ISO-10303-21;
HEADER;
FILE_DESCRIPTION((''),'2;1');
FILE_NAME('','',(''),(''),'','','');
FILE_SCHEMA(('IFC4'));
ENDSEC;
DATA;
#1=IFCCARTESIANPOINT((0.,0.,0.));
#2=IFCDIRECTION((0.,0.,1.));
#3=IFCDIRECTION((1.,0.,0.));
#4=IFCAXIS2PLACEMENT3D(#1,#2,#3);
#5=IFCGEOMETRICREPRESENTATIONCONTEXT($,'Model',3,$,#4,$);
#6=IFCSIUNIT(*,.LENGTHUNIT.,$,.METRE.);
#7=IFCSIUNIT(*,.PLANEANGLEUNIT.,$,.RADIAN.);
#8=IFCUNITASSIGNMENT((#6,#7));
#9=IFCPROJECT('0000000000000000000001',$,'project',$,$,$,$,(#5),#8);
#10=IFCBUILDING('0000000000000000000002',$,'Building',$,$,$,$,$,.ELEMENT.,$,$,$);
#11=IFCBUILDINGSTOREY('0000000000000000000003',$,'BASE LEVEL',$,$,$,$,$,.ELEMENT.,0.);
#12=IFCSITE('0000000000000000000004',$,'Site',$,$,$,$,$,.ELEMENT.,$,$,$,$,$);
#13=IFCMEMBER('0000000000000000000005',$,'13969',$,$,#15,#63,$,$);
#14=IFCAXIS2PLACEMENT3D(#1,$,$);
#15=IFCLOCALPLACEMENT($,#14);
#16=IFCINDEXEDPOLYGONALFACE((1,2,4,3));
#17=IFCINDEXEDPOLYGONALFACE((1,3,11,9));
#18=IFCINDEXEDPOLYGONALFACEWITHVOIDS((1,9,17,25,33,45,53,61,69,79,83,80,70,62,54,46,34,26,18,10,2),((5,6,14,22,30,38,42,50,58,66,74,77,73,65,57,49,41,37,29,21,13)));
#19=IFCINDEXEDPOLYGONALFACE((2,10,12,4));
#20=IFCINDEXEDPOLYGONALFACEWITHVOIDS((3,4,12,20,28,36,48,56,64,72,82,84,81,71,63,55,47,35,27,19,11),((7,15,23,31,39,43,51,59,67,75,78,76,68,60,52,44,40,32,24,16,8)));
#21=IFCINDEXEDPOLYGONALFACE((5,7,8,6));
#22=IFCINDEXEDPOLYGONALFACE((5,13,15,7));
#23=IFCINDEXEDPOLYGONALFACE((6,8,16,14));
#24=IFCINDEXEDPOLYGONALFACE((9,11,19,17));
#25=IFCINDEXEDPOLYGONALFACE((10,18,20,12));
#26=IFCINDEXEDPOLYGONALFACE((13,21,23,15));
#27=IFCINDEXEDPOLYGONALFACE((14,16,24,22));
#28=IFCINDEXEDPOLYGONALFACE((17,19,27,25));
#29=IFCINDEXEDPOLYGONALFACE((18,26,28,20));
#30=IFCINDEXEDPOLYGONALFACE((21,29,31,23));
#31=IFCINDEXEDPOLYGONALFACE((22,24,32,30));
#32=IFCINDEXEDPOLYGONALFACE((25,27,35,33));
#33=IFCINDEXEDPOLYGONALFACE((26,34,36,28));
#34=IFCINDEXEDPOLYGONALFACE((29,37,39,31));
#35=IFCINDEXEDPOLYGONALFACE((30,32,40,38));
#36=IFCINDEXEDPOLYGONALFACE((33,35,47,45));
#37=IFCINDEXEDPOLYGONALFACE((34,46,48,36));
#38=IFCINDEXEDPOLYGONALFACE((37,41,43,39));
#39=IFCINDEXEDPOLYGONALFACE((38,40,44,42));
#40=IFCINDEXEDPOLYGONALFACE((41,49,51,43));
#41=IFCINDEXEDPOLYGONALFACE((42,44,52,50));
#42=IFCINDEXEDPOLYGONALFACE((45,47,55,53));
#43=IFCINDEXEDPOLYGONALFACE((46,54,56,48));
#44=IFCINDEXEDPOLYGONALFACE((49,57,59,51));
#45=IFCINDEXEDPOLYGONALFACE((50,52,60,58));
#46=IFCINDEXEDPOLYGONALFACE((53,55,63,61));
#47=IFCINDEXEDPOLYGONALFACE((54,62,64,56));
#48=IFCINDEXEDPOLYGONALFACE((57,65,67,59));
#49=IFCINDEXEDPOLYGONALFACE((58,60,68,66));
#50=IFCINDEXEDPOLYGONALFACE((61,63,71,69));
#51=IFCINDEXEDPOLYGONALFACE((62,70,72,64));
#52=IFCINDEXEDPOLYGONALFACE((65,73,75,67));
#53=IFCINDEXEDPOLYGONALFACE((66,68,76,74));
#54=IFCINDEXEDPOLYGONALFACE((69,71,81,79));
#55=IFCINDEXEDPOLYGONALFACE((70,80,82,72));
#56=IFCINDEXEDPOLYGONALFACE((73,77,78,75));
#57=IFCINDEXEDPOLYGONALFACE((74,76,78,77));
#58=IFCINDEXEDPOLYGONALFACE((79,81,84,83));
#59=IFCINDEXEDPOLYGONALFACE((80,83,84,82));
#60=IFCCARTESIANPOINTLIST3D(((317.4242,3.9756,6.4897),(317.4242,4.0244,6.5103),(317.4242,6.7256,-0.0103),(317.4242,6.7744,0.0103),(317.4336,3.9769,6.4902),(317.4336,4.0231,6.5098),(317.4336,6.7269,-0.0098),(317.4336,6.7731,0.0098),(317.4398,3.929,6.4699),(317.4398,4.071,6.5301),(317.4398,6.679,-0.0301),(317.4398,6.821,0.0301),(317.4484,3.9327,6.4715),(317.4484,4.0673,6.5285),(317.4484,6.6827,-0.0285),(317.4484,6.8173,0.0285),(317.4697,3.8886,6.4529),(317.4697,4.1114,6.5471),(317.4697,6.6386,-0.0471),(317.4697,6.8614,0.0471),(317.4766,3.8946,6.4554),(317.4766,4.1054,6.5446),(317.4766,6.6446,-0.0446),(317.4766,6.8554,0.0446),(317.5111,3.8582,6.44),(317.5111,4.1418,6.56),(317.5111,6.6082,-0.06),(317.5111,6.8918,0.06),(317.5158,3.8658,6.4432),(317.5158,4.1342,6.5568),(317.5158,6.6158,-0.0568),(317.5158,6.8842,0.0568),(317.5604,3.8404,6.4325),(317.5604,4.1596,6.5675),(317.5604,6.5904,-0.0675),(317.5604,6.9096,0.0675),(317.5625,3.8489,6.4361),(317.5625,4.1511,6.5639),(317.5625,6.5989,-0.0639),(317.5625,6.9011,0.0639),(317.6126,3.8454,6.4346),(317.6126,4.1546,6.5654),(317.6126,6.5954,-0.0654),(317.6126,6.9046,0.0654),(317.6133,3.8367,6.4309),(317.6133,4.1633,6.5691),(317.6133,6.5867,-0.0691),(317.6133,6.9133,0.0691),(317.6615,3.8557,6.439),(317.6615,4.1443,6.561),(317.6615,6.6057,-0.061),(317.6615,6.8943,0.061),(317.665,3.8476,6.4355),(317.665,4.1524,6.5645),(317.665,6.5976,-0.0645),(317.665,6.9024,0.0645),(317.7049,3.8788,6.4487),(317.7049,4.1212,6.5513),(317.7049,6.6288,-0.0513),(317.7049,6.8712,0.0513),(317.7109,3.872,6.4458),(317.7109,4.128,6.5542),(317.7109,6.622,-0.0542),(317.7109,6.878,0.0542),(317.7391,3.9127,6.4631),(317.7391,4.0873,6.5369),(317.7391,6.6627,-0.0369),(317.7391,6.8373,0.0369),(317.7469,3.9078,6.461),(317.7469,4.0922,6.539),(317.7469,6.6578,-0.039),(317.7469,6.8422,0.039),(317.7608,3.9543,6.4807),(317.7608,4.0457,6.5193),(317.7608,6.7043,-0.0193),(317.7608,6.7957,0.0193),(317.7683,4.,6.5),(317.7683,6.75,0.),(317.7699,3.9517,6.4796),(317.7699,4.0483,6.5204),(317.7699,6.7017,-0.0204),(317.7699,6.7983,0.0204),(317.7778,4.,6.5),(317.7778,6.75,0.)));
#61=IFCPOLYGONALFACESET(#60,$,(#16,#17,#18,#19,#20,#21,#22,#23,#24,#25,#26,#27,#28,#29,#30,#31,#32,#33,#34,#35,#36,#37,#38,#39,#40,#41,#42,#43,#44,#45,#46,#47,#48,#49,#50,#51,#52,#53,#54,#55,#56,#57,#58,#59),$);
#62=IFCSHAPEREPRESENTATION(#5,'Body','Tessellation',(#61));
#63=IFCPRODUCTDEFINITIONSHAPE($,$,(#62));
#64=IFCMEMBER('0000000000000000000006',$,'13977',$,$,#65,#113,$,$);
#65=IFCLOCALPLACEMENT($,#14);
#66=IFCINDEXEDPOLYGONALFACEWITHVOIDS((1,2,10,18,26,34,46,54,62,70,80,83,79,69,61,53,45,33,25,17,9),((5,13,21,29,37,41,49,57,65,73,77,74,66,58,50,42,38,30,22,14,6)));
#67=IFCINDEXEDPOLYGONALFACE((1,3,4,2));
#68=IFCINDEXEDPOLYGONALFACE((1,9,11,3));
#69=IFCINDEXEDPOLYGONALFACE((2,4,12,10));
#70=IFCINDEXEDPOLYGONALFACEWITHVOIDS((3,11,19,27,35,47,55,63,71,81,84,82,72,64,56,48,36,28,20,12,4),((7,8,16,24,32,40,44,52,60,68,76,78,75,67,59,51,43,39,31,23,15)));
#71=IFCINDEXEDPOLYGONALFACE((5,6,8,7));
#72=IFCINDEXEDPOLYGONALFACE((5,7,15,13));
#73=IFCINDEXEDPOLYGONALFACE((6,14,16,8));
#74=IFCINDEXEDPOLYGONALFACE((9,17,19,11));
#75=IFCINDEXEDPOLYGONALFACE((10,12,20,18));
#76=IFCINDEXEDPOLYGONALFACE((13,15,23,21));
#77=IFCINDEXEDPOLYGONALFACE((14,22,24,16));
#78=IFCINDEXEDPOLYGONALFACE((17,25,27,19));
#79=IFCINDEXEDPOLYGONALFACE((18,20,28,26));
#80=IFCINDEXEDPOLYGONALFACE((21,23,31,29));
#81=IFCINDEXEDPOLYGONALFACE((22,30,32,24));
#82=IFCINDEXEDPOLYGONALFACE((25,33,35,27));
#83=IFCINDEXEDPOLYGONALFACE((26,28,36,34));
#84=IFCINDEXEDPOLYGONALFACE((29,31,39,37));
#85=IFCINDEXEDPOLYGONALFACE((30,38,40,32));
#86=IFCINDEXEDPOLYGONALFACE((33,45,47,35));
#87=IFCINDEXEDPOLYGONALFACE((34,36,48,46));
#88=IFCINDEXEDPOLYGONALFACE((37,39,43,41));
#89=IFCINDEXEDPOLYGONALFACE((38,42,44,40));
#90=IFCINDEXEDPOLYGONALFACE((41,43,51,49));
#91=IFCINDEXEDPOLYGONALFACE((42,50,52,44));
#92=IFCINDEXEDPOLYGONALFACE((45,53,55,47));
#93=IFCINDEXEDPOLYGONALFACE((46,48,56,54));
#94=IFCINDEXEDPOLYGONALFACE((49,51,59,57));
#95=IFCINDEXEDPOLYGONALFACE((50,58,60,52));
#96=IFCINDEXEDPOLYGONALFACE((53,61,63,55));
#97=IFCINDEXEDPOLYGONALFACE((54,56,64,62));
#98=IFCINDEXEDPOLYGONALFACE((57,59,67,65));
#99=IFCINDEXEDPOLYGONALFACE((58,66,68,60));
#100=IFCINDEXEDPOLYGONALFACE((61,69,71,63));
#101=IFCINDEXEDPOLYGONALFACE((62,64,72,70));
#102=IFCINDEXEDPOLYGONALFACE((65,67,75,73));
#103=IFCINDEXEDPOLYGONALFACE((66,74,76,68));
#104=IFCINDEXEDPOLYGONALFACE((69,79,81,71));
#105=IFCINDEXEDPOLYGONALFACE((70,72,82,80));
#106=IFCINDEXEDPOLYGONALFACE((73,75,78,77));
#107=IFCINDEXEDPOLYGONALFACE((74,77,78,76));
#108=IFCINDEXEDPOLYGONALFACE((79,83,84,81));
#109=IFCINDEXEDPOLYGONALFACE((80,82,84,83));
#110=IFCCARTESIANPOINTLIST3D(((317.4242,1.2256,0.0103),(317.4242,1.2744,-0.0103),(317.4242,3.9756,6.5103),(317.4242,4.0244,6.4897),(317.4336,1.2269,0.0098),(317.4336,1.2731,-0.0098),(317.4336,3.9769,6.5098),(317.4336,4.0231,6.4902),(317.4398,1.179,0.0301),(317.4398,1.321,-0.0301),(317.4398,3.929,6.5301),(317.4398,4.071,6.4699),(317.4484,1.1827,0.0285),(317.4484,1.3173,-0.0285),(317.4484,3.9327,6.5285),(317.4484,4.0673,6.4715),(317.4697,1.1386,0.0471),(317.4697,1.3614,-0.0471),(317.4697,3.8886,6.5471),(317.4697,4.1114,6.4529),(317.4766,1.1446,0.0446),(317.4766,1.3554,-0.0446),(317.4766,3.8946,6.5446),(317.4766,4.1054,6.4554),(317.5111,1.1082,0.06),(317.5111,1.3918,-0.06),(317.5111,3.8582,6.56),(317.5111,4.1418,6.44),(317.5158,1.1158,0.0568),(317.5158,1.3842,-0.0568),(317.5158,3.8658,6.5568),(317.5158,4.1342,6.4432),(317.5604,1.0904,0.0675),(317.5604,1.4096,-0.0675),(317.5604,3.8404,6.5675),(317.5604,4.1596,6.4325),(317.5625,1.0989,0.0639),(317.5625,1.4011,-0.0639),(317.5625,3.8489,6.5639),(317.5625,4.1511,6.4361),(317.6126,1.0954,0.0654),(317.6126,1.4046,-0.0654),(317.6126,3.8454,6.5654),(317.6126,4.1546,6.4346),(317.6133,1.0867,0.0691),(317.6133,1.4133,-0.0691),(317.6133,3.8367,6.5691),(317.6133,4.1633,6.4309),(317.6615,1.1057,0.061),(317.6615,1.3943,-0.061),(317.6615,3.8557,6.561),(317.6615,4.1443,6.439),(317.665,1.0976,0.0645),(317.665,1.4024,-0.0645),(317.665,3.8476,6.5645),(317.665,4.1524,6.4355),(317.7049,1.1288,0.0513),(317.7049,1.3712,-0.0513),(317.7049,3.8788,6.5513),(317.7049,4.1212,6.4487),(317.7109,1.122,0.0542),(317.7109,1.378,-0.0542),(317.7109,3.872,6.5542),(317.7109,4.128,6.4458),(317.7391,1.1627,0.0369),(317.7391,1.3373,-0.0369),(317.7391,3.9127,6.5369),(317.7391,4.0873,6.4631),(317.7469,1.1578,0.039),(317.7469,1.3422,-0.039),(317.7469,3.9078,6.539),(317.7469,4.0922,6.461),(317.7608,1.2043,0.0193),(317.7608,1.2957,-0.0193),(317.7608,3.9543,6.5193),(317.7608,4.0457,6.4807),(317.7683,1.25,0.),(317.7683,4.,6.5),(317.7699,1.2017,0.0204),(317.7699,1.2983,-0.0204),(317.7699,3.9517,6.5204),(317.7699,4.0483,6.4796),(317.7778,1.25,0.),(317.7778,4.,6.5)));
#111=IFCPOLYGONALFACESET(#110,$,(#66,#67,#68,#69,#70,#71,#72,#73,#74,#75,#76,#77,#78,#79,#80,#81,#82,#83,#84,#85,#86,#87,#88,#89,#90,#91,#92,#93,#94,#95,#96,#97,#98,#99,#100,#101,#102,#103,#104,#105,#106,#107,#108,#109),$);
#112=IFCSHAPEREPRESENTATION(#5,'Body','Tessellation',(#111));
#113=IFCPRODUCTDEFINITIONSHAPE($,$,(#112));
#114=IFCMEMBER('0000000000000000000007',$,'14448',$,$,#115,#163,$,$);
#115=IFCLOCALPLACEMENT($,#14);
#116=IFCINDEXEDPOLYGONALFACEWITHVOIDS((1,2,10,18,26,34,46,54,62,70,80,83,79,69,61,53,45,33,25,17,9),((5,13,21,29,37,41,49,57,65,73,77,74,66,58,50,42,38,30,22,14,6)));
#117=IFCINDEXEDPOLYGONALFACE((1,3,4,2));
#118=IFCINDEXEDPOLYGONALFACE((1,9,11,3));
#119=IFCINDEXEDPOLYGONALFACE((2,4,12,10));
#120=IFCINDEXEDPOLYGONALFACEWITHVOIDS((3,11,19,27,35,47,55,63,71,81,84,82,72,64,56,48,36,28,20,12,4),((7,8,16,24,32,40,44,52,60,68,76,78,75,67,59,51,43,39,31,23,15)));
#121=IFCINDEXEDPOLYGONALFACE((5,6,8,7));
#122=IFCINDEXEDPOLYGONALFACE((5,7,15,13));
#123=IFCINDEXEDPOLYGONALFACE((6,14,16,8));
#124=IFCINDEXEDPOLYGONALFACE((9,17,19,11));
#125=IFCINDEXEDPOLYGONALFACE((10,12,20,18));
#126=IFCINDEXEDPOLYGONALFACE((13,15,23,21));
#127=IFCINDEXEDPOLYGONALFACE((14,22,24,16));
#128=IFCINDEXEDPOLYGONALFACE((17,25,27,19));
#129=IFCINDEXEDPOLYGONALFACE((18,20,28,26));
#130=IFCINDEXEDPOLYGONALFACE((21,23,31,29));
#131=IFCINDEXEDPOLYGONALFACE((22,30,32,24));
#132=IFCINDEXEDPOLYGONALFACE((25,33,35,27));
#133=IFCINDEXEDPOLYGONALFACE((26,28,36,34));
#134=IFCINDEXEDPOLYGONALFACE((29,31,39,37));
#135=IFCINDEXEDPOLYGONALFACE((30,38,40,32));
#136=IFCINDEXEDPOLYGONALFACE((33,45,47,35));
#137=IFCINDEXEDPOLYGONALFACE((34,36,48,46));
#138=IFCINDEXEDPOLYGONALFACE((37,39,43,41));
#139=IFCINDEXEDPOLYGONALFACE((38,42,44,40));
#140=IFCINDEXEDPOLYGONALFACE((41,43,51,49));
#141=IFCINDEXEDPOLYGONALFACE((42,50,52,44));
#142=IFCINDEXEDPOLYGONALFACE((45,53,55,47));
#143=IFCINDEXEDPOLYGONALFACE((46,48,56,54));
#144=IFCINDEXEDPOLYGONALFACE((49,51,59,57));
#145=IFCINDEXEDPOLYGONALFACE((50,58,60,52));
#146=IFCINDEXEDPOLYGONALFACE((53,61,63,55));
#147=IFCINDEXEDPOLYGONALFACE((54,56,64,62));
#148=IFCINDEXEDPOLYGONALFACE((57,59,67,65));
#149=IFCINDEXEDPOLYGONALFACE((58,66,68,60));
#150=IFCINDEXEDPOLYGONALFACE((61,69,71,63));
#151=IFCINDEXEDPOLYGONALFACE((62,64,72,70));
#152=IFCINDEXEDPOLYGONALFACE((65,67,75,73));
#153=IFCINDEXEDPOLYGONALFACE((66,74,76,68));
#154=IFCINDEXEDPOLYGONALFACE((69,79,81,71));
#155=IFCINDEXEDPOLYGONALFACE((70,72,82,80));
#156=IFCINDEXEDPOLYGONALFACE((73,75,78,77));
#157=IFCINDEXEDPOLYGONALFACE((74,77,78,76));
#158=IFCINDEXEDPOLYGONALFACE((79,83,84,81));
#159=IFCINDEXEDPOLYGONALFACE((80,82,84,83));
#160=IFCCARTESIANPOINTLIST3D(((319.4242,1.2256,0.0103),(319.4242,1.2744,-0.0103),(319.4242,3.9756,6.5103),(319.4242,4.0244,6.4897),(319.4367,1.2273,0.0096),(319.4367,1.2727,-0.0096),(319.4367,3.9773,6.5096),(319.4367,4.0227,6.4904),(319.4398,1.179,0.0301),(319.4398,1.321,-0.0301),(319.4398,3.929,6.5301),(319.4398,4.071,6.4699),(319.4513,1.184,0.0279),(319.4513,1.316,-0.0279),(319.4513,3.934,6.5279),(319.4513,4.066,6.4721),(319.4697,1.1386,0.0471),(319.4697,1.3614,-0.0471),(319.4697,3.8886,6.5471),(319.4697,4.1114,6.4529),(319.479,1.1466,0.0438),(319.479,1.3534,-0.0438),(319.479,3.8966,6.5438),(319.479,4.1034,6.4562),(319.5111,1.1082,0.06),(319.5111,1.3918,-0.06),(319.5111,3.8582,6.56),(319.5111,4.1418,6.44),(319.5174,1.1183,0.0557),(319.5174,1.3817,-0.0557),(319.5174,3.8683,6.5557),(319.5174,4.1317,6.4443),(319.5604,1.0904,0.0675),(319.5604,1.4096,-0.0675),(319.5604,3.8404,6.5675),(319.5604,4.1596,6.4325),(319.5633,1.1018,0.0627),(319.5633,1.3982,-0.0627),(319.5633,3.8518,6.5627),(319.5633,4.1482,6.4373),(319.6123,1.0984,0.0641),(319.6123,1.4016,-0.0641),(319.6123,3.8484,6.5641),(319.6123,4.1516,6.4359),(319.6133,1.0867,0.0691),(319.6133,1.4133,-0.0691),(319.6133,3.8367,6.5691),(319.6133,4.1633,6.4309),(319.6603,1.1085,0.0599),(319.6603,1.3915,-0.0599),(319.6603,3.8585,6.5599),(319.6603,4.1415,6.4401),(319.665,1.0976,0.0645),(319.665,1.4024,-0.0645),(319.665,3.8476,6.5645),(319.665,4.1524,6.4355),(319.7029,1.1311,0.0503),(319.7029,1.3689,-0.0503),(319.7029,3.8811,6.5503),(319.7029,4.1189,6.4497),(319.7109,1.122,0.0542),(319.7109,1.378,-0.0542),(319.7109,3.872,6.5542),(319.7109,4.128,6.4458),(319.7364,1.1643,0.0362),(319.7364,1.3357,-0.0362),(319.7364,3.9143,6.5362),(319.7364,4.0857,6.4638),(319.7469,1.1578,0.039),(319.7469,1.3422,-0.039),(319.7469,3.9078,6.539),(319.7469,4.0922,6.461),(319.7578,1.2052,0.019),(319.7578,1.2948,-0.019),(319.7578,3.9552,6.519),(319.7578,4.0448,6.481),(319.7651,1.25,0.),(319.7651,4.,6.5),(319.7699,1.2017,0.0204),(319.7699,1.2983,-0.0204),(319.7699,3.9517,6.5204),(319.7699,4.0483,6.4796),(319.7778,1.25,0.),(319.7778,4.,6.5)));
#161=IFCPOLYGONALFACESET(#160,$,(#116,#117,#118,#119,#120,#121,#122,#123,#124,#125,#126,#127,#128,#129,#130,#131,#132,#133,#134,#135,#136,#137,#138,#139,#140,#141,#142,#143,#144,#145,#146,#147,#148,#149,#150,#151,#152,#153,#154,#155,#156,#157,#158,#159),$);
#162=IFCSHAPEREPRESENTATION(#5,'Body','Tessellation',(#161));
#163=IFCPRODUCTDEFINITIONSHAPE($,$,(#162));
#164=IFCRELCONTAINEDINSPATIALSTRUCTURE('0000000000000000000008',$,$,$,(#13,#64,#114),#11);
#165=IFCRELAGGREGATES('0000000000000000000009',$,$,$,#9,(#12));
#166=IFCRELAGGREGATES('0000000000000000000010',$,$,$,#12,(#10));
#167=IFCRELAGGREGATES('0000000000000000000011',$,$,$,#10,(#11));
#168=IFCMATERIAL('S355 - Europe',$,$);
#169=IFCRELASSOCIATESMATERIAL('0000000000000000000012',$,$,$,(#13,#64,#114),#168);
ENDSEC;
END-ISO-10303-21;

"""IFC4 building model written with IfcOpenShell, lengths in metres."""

from ifc_helpers import new_model, si_unit, frame, origin_with_axes, origin_2d_with_axis, place, context, project, spatial, hollow_circle, extrude, material, material_profile, profile_set, profile_usage, element, save


model = new_model("IFC4")

# Units and contexts
model_context = context("Model", 3, world=origin_with_axes())
ifc_project = project(units=[si_unit("LENGTHUNIT", "METRE"), si_unit("PLANEANGLEUNIT", "RADIAN")], contexts=[model_context])

# Site, building, storey
site = spatial("IfcSite", under=ifc_project, Name="Site", CompositionType="ELEMENT")
building = spatial("IfcBuilding", under=site, Name="Building", CompositionType="ELEMENT")
storey = spatial("IfcBuildingStorey", under=building, Name="BASE LEVEL", CompositionType="ELEMENT", Elevation=0.0)

# Shared definitions
ifc_material = material(Name="S355 - Europe")

# Members
ifc_material_profile_1 = material_profile(ifc_material, hollow_circle(Radius=0.1778, WallThickness=0.0095, at=origin_2d_with_axis()))
ifc_profile_set_1 = profile_set([ifc_material_profile_1])
ifc_profile_usage_1 = profile_usage(ifc_profile_set_1, cardinal=10)
member_1_placement = place(None, frame((317.6, 6.75, 0.0), z_axis=(0.0, -0.38964, 0.920967), x_axis=(1.0, 0.0, 0.0)))
element("IfcMember", 1, at=member_1_placement, inside=storey, material=ifc_profile_usage_1, Name="13969", context=model_context, shape_type="SweptSolid", body=[
    extrude(hollow_circle(Radius=0.1778, WallThickness=0.0095, at=origin_2d_with_axis()), origin_with_axes(), (0.0, 0.0, 1.0), 7.0578),
])
ifc_material_profile_2 = material_profile(ifc_material, hollow_circle(Radius=0.1778, WallThickness=0.0095, at=origin_2d_with_axis()))
ifc_profile_set_2 = profile_set([ifc_material_profile_2])
ifc_profile_usage_2 = profile_usage(ifc_profile_set_2, cardinal=10)
member_2_placement = place(None, frame((317.6, 4.0, 6.5), z_axis=(0.0, -0.38964, -0.920967), x_axis=(1.0, 0.0, 0.0)))
element("IfcMember", 2, at=member_2_placement, inside=storey, material=ifc_profile_usage_2, Name="13977", context=model_context, shape_type="SweptSolid", body=[
    extrude(hollow_circle(Radius=0.1778, WallThickness=0.0095, at=origin_2d_with_axis()), origin_with_axes(), (0.0, 0.0, 1.0), 7.0578),
])
ifc_material_profile_3 = material_profile(ifc_material, hollow_circle(Radius=0.1778, WallThickness=0.0127, at=origin_2d_with_axis()))
ifc_profile_set_3 = profile_set([ifc_material_profile_3])
ifc_profile_usage_3 = profile_usage(ifc_profile_set_3, cardinal=10)
member_3_placement = place(None, frame((319.6, 4.0, 6.5), z_axis=(0.0, -0.38964, -0.920967), x_axis=(1.0, 0.0, 0.0)))
element("IfcMember", 3, at=member_3_placement, inside=storey, material=ifc_profile_usage_3, Name="14448", context=model_context, shape_type="SweptSolid", body=[
    extrude(hollow_circle(Radius=0.1778, WallThickness=0.0127, at=origin_2d_with_axis()), origin_with_axes(), (0.0, 0.0, 1.0), 7.0578),
])

save(model, "model.ifc")
